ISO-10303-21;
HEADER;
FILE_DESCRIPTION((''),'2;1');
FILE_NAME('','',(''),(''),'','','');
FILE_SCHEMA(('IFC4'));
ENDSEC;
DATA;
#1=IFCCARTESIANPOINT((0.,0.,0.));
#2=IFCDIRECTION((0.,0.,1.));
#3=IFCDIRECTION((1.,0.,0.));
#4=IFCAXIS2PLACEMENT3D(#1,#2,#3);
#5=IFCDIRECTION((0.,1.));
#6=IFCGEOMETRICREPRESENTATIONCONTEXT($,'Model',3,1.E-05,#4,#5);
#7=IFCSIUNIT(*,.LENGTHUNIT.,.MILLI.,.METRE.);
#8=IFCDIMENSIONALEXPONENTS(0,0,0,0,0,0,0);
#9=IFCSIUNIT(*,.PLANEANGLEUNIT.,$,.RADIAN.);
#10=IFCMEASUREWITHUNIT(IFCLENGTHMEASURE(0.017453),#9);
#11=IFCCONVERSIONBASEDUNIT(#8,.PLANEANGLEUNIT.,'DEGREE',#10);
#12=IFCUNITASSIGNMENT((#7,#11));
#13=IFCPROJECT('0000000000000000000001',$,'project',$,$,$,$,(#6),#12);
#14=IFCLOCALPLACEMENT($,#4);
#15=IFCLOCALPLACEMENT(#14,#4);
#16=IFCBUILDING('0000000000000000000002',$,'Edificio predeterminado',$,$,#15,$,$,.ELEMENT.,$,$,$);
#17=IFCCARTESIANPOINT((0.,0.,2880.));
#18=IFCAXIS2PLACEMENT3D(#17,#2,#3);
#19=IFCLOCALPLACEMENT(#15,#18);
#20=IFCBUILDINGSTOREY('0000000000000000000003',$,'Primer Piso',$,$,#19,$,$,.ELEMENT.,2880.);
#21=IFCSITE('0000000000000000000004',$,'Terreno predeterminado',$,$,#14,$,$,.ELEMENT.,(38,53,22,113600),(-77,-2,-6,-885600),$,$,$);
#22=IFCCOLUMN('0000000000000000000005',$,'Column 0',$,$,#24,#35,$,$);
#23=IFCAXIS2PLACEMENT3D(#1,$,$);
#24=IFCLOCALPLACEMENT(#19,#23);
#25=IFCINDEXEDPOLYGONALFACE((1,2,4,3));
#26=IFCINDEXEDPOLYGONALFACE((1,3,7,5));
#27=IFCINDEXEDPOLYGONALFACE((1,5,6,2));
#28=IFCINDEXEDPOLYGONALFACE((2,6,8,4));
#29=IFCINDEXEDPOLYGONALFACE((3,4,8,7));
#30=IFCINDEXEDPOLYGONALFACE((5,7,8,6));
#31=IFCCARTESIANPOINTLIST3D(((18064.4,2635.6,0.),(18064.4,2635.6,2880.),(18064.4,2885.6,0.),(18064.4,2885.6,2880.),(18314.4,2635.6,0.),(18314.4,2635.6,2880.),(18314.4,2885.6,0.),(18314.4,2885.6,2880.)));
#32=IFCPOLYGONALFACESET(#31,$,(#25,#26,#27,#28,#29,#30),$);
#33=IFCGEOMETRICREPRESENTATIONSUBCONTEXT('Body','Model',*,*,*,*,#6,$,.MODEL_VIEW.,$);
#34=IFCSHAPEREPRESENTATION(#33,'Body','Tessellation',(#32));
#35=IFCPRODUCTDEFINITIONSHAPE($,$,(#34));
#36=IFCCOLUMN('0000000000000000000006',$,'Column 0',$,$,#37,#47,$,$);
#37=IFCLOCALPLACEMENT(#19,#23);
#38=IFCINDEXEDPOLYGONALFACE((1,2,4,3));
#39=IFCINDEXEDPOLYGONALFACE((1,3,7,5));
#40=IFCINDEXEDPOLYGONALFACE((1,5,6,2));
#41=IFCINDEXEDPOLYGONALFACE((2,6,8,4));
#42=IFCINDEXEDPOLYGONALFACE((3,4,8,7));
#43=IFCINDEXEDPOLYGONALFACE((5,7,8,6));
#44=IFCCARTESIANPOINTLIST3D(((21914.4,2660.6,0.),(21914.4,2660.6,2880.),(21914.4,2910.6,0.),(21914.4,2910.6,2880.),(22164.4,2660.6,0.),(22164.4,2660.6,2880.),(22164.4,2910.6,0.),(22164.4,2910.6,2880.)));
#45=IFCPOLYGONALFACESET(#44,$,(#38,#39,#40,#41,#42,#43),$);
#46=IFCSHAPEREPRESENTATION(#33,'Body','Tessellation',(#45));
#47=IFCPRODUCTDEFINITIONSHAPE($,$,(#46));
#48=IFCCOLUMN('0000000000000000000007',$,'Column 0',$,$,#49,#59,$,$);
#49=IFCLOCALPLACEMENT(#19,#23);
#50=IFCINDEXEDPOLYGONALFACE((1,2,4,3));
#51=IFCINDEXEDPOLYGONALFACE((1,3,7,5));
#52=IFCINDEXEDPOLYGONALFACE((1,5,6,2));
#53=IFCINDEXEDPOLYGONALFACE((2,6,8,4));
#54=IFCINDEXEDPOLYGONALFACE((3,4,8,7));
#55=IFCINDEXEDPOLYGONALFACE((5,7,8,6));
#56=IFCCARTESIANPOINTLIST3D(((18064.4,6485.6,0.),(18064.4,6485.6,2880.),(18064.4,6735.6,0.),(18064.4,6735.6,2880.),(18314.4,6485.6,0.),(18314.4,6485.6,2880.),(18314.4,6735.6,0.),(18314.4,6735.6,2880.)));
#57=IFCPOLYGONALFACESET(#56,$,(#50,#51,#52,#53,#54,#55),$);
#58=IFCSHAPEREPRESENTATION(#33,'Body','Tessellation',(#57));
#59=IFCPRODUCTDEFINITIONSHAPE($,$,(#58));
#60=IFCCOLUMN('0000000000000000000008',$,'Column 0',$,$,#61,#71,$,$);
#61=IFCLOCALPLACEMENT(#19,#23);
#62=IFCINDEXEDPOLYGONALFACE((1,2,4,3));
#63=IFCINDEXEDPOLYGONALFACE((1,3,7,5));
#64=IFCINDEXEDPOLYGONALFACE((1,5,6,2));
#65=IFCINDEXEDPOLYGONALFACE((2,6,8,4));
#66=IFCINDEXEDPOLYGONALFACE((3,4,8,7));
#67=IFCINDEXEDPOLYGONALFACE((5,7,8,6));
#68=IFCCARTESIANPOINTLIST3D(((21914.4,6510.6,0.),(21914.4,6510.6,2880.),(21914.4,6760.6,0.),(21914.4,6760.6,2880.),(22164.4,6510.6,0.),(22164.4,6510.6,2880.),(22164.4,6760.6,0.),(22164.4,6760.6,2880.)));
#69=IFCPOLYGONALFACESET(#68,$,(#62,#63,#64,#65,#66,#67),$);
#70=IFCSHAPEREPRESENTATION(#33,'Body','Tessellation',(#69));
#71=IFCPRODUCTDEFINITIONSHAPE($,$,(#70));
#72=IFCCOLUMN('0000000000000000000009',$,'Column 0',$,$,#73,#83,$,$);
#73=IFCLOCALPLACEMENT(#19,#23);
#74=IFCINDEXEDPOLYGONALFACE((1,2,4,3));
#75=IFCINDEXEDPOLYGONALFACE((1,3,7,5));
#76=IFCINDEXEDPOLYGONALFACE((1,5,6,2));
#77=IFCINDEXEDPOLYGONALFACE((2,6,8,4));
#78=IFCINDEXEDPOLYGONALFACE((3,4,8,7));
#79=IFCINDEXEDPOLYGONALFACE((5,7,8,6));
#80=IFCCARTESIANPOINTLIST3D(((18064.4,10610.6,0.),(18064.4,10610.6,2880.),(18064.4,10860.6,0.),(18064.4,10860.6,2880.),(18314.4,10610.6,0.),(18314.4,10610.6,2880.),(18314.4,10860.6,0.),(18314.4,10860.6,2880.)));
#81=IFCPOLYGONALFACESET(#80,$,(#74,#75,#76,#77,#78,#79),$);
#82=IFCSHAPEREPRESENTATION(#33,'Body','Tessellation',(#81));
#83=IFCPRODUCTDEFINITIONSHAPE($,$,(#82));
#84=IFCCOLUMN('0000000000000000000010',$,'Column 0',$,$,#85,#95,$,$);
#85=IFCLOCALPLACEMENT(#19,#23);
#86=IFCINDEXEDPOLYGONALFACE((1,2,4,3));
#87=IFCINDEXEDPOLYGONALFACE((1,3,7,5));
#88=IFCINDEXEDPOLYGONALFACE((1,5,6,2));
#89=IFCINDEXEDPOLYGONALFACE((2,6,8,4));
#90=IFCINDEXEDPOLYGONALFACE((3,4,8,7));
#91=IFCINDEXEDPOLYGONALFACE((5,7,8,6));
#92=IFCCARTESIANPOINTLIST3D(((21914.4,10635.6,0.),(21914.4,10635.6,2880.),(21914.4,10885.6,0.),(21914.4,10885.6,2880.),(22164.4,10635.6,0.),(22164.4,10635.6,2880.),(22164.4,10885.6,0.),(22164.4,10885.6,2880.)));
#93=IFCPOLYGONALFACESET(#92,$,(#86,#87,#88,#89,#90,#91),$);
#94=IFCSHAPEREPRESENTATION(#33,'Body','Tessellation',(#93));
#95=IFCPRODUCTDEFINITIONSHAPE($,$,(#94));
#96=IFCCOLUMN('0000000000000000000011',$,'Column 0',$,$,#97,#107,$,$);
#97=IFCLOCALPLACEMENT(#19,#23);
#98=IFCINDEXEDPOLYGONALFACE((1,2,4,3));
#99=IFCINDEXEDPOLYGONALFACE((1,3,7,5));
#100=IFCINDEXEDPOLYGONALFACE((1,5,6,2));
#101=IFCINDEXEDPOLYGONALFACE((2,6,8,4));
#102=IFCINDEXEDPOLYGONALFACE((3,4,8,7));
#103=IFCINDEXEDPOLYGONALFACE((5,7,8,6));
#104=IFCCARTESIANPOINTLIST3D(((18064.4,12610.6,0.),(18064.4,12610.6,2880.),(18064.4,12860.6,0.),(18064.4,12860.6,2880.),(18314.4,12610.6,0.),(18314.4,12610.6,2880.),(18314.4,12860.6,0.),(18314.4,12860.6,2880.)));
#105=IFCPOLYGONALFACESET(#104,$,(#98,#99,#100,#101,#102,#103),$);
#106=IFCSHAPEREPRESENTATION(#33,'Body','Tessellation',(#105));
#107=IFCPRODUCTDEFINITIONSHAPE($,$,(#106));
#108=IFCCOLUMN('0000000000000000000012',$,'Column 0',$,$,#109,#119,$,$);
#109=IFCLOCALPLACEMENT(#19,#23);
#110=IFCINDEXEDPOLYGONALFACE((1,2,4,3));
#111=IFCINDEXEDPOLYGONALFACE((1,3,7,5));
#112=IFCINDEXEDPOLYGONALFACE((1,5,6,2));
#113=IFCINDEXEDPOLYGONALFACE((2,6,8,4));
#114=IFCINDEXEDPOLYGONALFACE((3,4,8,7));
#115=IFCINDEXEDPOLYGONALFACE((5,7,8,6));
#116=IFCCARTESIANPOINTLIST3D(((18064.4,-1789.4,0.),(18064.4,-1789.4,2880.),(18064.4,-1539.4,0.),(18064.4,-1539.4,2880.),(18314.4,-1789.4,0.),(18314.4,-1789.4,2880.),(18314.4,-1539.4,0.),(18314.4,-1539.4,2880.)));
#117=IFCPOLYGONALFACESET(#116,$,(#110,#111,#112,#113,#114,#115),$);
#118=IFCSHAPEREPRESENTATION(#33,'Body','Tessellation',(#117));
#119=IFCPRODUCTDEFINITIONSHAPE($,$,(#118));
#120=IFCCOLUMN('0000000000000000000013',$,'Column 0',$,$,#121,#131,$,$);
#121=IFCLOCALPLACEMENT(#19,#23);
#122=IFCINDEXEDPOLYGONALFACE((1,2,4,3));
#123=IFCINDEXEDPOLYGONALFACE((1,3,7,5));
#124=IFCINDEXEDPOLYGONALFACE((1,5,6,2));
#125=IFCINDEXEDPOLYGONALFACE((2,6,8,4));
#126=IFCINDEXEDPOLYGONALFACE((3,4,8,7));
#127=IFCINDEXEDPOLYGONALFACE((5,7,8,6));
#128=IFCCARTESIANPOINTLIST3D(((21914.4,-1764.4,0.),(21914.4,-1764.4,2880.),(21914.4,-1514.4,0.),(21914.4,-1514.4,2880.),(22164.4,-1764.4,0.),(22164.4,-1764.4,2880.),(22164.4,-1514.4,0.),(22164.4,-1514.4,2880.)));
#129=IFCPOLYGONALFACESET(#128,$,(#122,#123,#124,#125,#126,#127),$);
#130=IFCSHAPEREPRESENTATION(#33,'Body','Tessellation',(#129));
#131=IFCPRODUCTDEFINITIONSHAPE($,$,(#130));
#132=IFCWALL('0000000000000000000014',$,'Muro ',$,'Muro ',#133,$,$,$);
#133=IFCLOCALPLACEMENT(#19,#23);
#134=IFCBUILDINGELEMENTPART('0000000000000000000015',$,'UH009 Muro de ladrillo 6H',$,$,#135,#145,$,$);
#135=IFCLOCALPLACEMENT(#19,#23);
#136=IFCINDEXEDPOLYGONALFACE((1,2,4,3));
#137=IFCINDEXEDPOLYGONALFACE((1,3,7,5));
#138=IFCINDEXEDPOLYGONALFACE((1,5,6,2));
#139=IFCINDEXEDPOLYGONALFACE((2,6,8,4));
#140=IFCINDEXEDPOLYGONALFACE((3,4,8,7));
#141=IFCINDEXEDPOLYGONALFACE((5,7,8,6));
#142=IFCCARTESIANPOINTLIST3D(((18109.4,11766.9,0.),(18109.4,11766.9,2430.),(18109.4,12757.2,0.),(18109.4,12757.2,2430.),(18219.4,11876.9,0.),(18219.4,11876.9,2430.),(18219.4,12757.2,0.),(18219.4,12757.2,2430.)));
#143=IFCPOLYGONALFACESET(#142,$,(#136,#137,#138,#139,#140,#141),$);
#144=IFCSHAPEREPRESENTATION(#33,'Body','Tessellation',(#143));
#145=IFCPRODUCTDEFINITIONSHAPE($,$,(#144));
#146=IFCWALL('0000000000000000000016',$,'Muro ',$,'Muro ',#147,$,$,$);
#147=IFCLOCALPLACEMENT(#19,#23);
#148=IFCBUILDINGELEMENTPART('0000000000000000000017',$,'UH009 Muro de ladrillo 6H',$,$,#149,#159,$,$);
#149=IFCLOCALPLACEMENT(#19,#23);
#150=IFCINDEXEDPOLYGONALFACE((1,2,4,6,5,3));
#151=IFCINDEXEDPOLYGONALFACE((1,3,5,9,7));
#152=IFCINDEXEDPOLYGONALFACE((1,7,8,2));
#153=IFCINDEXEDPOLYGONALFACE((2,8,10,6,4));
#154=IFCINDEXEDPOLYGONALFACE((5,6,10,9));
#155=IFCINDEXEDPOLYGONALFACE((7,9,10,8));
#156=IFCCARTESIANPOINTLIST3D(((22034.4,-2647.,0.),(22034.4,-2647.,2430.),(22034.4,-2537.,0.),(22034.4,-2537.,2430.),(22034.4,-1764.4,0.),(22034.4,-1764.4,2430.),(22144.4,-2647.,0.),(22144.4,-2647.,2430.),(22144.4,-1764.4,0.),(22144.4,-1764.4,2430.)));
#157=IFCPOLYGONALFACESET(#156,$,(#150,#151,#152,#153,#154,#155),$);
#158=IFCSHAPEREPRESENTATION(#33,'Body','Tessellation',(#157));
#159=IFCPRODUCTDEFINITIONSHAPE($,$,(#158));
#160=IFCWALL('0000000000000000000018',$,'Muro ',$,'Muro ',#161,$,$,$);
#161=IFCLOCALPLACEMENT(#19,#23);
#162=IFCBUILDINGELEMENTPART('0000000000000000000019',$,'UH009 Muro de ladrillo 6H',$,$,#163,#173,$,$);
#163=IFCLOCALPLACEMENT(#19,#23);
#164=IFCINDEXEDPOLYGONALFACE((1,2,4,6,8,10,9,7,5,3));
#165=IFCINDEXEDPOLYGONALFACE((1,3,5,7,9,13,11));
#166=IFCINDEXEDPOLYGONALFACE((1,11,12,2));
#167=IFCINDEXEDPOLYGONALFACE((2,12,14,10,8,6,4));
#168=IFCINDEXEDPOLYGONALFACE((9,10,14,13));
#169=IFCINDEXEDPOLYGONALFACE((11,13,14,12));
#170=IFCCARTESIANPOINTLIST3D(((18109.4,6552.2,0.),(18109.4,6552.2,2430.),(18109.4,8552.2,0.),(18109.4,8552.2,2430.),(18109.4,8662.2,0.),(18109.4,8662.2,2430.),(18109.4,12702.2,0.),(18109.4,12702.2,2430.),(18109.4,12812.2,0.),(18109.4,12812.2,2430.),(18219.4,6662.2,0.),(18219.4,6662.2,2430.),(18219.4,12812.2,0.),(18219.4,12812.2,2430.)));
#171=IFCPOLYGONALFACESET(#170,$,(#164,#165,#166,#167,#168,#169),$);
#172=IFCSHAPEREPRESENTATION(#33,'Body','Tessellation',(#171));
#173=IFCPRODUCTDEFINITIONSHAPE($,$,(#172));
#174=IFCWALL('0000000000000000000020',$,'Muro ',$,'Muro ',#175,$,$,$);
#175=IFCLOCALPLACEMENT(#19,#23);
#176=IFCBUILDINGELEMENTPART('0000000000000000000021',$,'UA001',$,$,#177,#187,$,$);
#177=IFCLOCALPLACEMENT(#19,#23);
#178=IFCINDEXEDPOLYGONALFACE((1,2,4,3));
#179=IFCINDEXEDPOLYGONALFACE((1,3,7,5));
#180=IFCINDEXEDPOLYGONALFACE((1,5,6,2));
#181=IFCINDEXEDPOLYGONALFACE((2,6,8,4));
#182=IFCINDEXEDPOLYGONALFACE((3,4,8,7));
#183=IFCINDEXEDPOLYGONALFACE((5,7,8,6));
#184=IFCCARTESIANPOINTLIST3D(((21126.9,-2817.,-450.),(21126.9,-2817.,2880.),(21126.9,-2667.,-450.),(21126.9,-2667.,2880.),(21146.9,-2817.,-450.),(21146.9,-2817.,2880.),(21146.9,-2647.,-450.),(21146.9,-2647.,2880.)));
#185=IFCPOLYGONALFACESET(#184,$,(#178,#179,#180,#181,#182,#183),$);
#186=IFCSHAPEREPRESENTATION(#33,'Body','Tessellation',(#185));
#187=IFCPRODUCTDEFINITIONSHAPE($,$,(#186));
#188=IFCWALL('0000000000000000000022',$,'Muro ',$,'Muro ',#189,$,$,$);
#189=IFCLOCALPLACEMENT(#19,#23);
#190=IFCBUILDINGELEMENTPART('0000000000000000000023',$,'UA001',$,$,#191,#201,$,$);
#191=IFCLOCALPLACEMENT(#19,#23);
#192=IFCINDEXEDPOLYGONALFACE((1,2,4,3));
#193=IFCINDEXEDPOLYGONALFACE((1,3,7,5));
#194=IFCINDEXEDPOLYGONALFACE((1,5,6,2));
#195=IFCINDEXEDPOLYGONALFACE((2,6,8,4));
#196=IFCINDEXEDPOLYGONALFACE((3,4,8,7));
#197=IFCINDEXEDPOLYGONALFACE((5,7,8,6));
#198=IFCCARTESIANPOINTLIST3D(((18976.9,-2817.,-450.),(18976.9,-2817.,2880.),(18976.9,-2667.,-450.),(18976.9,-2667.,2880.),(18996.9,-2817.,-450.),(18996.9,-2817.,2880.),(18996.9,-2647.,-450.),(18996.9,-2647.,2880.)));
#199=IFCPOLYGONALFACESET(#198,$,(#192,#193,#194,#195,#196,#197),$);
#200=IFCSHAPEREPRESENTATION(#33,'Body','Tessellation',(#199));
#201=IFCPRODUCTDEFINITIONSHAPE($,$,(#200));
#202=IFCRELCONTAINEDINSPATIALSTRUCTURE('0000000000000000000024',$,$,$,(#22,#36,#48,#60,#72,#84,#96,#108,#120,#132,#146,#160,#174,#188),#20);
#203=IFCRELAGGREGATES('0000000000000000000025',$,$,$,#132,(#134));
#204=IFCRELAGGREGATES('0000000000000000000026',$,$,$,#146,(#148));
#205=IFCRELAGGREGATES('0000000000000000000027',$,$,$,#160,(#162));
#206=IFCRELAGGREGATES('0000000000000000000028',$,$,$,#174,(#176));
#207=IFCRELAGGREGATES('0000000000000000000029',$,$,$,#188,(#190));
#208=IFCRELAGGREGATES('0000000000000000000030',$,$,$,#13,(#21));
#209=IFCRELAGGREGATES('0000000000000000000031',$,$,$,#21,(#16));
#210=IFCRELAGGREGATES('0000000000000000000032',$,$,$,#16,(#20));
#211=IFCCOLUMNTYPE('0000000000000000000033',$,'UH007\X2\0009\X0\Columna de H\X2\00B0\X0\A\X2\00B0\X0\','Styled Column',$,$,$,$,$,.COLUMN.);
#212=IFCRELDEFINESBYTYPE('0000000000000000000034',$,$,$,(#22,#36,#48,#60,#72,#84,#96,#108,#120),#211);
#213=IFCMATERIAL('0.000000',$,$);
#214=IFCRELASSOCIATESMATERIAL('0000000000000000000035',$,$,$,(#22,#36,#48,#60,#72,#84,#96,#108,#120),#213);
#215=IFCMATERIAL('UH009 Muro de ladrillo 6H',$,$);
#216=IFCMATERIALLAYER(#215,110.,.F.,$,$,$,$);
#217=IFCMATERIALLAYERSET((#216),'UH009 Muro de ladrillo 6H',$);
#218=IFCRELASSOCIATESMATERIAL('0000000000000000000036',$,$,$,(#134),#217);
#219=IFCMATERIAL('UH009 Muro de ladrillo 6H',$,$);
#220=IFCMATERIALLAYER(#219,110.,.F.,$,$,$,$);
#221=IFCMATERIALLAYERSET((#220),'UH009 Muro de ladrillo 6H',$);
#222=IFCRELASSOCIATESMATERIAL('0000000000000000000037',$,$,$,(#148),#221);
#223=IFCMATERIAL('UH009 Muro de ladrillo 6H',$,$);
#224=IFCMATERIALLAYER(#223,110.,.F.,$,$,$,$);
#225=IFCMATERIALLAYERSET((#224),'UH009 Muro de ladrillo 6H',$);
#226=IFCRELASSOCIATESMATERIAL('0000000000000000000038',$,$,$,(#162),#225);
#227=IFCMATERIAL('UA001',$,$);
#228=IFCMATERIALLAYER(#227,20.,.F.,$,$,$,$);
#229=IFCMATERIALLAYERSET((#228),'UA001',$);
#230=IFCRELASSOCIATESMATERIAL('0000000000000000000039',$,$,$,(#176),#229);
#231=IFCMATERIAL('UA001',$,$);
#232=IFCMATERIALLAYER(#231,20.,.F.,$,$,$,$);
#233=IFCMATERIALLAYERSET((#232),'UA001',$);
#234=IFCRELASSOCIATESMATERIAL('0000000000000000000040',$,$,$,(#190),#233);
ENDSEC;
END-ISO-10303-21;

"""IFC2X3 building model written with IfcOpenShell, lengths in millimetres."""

from ifc_helpers import new_model, entity, si_unit, converted_unit, direction, frame, origin_with_axes, place, context, subcontext, project, spatial, polyline, outline, extrude, clip, bounded_halfspace, material, layer, layer_set, layer_usage, type_object, element, aggregate, save


model = new_model("IFC2X3")

# Units and contexts
model_context = context("Model", 3, precision=1e-05, world=origin_with_axes(), true_north=direction((0.0, 1.0)))
body_context = subcontext(model_context, "Body", "Model", "MODEL_VIEW")
ifc_project = project(units=[si_unit("LENGTHUNIT", "METRE", prefix="MILLI"), converted_unit("PLANEANGLEUNIT", "DEGREE", entity("IfcLengthMeasure", 0.017453), si_unit("PLANEANGLEUNIT", "RADIAN"), dimensions=[0, 0, 0, 0, 0, 0, 0])], contexts=[model_context])

# Site, building, storey
site_placement = place(None, origin_with_axes())
site = spatial("IfcSite", under=ifc_project, at=site_placement, Name="Terreno predeterminado", CompositionType="ELEMENT", RefLatitude=(38, 53, 22, 113600), RefLongitude=(-77, -2, -6, -885600))
building_placement = place(site_placement, origin_with_axes())
building = spatial("IfcBuilding", under=site, at=building_placement, Name="Edificio predeterminado", CompositionType="ELEMENT")
storey_placement = place(building_placement, frame((0.0, 0.0, 2880.0), z_axis=(0.0, 0.0, 1.0), x_axis=(1.0, 0.0, 0.0)))
storey = spatial("IfcBuildingStorey", under=building, at=storey_placement, Name="Primer Piso", CompositionType="ELEMENT", Elevation=2880.0)

# Columns
ifc_material_1 = material(Name="0.000000")
column_type = type_object("IfcColumnType", Name="UH007\tColumna de H°A°", Description="Styled Column", PredefinedType="COLUMN")
for number, where, z_axis, x_axis, name in (
    (1, (18189.4, 2760.6, 0.0), (0.0, 0.0, 1.0), (1.0, 0.0, 0.0), "Column 0"),
    (2, (22039.4, 2785.6, 0.0), (0.0, 0.0, 1.0), (1.0, 0.0, 0.0), "Column 0"),
    (3, (18189.4, 6610.6, 0.0), (0.0, 0.0, 1.0), (1.0, 0.0, 0.0), "Column 0"),
    (4, (22039.4, 6635.6, 0.0), (0.0, 0.0, 1.0), (1.0, 0.0, 0.0), "Column 0"),
    (5, (18189.4, 10735.6, 0.0), (0.0, 0.0, 1.0), (1.0, 0.0, 0.0), "Column 0"),
    (6, (22039.4, 10760.6, 0.0), (0.0, 0.0, 1.0), (1.0, 0.0, 0.0), "Column 0"),
    (7, (18189.4, 12735.6, 0.0), (0.0, 0.0, 1.0), (1.0, 0.0, 0.0), "Column 0"),
    (8, (18189.4, -1664.4, 0.0), (0.0, 0.0, 1.0), (1.0, 0.0, 0.0), "Column 0"),
    (9, (22039.4, -1639.4, 0.0), (0.0, 0.0, 1.0), (1.0, 0.0, 0.0), "Column 0"),
):
    element("IfcColumn", number, at=place(storey_placement, frame(where, z_axis=z_axis, x_axis=x_axis)), inside=storey, type_object=column_type, material=ifc_material_1, Name=name, context=body_context, shape_type="SweptSolid", body=[
        extrude(outline(polyline([(-125.0, -125.0), (125.0, -125.0), (125.0, 125.0), (-125.0, 125.0), (-125.0, -125.0)])), origin_with_axes(), (0.0, 0.0, 1.0), 2880.0),
    ])

# Walls, building element parts
wall_1_placement = place(storey_placement, frame((18164.4, 11821.9, 0.0), z_axis=(0.0, 0.0, 1.0), x_axis=(0.0, 1.0, 0.0)))
wall_1 = element("IfcWall", 10, at=wall_1_placement, inside=storey, Name="Muro ", ObjectType="Muro ")
ifc_material_2 = material(Name="UH009 Muro de ladrillo 6H")
ifc_layer_1 = layer(ifc_material_2, 110.0, ventilated=False)
ifc_layer_set_1 = layer_set([ifc_layer_1], Name="UH009 Muro de ladrillo 6H")
ifc_layer_usage_1 = layer_usage(ifc_layer_set_1, "AXIS2", "NEGATIVE", -55.0)
building_element_part_1_placement = place(wall_1_placement, origin_with_axes())
building_element_part_1 = element("IfcBuildingElementPart", 11, at=building_element_part_1_placement, material=ifc_layer_usage_1, Name="UH009 Muro de ladrillo 6H", context=body_context, shape_type="SweptSolid", body=[
    extrude(outline(polyline([(935.2, 55.0), (935.2, -55.0), (55.0, -55.0), (-55.0, 55.0), (935.2, 55.0)])), origin_with_axes(), (0.0, 0.0, 1.0), 2430.0),
])
aggregate(wall_1, [building_element_part_1])
wall_2_placement = place(storey_placement, frame((22089.4, -1764.4, 0.0), z_axis=(0.0, 0.0, 1.0), x_axis=(0.0, -1.0, 0.0)))
wall_2 = element("IfcWall", 12, at=wall_2_placement, inside=storey, Name="Muro ", ObjectType="Muro ")
ifc_material_3 = material(Name="UH009 Muro de ladrillo 6H")
ifc_layer_2 = layer(ifc_material_3, 110.0, ventilated=False)
ifc_layer_set_2 = layer_set([ifc_layer_2], Name="UH009 Muro de ladrillo 6H")
ifc_layer_usage_2 = layer_usage(ifc_layer_set_2, "AXIS2", "NEGATIVE", -55.0)
building_element_part_2_placement = place(wall_2_placement, origin_with_axes())
building_element_part_2 = element("IfcBuildingElementPart", 13, at=building_element_part_2_placement, material=ifc_layer_usage_2, Name="UH009 Muro de ladrillo 6H", context=body_context, shape_type="SweptSolid", body=[
    extrude(outline(polyline([(882.6, 55.0), (882.6, -55.0), (772.6, -55.0), (0.0, -55.0), (0.0, 55.0), (882.6, 55.0)])), origin_with_axes(), (0.0, 0.0, 1.0), 2430.0),
])
aggregate(wall_2, [building_element_part_2])
wall_3_placement = place(storey_placement, frame((18164.4, 12757.2, 0.0), z_axis=(0.0, 0.0, 1.0), x_axis=(0.0, -1.0, 0.0)))
wall_3 = element("IfcWall", 14, at=wall_3_placement, inside=storey, Name="Muro ", ObjectType="Muro ")
ifc_material_4 = material(Name="UH009 Muro de ladrillo 6H")
ifc_layer_3 = layer(ifc_material_4, 110.0, ventilated=False)
ifc_layer_set_3 = layer_set([ifc_layer_3], Name="UH009 Muro de ladrillo 6H")
ifc_layer_usage_3 = layer_usage(ifc_layer_set_3, "AXIS2", "NEGATIVE", -55.0)
building_element_part_3_placement = place(wall_3_placement, origin_with_axes())
building_element_part_3 = element("IfcBuildingElementPart", 15, at=building_element_part_3_placement, material=ifc_layer_usage_3, Name="UH009 Muro de ladrillo 6H", context=body_context, shape_type="SweptSolid", body=[
    extrude(outline(polyline([(6095.0, 55.0), (6205.0, -55.0), (4205.0, -55.0), (4095.0, -55.0), (55.0, -55.0), (-55.0, -55.0), (-55.0, 55.0), (6095.0, 55.0)])), origin_with_axes(), (0.0, 0.0, 1.0), 2430.0),
])
aggregate(wall_3, [building_element_part_3])
wall_4_placement = place(storey_placement, frame((21201.9, -2817.0, 0.0), z_axis=(0.0, 0.0, 1.0), x_axis=(0.0, 1.0, 0.0)))
wall_4 = element("IfcWall", 16, at=wall_4_placement, inside=storey, Name="Muro ", ObjectType="Muro ")
ifc_material_5 = material(Name="UA001")
ifc_layer_4 = layer(ifc_material_5, 20.0, ventilated=False)
ifc_layer_set_4 = layer_set([ifc_layer_4], Name="UA001")
ifc_layer_usage_4 = layer_usage(ifc_layer_set_4, "AXIS2", "NEGATIVE", -75.0)
building_element_part_4_placement = place(wall_4_placement, origin_with_axes())
building_element_part_4 = element("IfcBuildingElementPart", 17, at=building_element_part_4_placement, material=ifc_layer_usage_4, Name="UA001", context=body_context, shape_type="Clipping", body=[
    clip(clip(extrude(outline(polyline([(150.0, 75.0), (170.0, 55.0), (0.0, 55.0), (0.0, 75.0), (150.0, 75.0)])), frame((0.0, 0.0, -450.0), z_axis=(0.0, 0.0, 1.0), x_axis=(1.0, 0.0, 0.0)), (0.0, 0.0, 1.0), 3330.0), bounded_halfspace(frame((0.0, 0.0, -450.0), z_axis=(0.0, 0.0, 1.0), x_axis=(1.0, 0.0, 0.0)), True, origin_with_axes(), polyline([(-150.0, -150.0), (375.0, -150.0), (375.0, 150.0), (-150.0, 150.0), (-150.0, -150.0)]))), bounded_halfspace(frame((0.0, 0.0, 2880.0), z_axis=(0.0, 0.0, 1.0), x_axis=(1.0, 0.0, 0.0)), False, origin_with_axes(), polyline([(-150.0, -150.0), (375.0, -150.0), (375.0, 150.0), (-150.0, 150.0), (-150.0, -150.0)]))),
])
aggregate(wall_4, [building_element_part_4])
wall_5_placement = place(storey_placement, frame((19051.9, -2817.0, 0.0), z_axis=(0.0, 0.0, 1.0), x_axis=(0.0, 1.0, 0.0)))
wall_5 = element("IfcWall", 18, at=wall_5_placement, inside=storey, Name="Muro ", ObjectType="Muro ")
ifc_material_6 = material(Name="UA001")
ifc_layer_5 = layer(ifc_material_6, 20.0, ventilated=False)
ifc_layer_set_5 = layer_set([ifc_layer_5], Name="UA001")
ifc_layer_usage_5 = layer_usage(ifc_layer_set_5, "AXIS2", "NEGATIVE", -75.0)
building_element_part_5_placement = place(wall_5_placement, origin_with_axes())
building_element_part_5 = element("IfcBuildingElementPart", 19, at=building_element_part_5_placement, material=ifc_layer_usage_5, Name="UA001", context=body_context, shape_type="Clipping", body=[
    clip(clip(extrude(outline(polyline([(150.0, 75.0), (170.0, 55.0), (0.0, 55.0), (0.0, 75.0), (150.0, 75.0)])), frame((0.0, 0.0, -450.0), z_axis=(0.0, 0.0, 1.0), x_axis=(1.0, 0.0, 0.0)), (0.0, 0.0, 1.0), 3330.0), bounded_halfspace(frame((0.0, 0.0, -450.0), z_axis=(0.0, 0.0, 1.0), x_axis=(1.0, 0.0, 0.0)), True, origin_with_axes(), polyline([(-150.0, -150.0), (375.0, -150.0), (375.0, 150.0), (-150.0, 150.0), (-150.0, -150.0)]))), bounded_halfspace(frame((0.0, 0.0, 2880.0), z_axis=(0.0, 0.0, 1.0), x_axis=(1.0, 0.0, 0.0)), False, origin_with_axes(), polyline([(-150.0, -150.0), (375.0, -150.0), (375.0, 150.0), (-150.0, 150.0), (-150.0, -150.0)]))),
])
aggregate(wall_5, [building_element_part_5])

save(model, "model.ifc")
